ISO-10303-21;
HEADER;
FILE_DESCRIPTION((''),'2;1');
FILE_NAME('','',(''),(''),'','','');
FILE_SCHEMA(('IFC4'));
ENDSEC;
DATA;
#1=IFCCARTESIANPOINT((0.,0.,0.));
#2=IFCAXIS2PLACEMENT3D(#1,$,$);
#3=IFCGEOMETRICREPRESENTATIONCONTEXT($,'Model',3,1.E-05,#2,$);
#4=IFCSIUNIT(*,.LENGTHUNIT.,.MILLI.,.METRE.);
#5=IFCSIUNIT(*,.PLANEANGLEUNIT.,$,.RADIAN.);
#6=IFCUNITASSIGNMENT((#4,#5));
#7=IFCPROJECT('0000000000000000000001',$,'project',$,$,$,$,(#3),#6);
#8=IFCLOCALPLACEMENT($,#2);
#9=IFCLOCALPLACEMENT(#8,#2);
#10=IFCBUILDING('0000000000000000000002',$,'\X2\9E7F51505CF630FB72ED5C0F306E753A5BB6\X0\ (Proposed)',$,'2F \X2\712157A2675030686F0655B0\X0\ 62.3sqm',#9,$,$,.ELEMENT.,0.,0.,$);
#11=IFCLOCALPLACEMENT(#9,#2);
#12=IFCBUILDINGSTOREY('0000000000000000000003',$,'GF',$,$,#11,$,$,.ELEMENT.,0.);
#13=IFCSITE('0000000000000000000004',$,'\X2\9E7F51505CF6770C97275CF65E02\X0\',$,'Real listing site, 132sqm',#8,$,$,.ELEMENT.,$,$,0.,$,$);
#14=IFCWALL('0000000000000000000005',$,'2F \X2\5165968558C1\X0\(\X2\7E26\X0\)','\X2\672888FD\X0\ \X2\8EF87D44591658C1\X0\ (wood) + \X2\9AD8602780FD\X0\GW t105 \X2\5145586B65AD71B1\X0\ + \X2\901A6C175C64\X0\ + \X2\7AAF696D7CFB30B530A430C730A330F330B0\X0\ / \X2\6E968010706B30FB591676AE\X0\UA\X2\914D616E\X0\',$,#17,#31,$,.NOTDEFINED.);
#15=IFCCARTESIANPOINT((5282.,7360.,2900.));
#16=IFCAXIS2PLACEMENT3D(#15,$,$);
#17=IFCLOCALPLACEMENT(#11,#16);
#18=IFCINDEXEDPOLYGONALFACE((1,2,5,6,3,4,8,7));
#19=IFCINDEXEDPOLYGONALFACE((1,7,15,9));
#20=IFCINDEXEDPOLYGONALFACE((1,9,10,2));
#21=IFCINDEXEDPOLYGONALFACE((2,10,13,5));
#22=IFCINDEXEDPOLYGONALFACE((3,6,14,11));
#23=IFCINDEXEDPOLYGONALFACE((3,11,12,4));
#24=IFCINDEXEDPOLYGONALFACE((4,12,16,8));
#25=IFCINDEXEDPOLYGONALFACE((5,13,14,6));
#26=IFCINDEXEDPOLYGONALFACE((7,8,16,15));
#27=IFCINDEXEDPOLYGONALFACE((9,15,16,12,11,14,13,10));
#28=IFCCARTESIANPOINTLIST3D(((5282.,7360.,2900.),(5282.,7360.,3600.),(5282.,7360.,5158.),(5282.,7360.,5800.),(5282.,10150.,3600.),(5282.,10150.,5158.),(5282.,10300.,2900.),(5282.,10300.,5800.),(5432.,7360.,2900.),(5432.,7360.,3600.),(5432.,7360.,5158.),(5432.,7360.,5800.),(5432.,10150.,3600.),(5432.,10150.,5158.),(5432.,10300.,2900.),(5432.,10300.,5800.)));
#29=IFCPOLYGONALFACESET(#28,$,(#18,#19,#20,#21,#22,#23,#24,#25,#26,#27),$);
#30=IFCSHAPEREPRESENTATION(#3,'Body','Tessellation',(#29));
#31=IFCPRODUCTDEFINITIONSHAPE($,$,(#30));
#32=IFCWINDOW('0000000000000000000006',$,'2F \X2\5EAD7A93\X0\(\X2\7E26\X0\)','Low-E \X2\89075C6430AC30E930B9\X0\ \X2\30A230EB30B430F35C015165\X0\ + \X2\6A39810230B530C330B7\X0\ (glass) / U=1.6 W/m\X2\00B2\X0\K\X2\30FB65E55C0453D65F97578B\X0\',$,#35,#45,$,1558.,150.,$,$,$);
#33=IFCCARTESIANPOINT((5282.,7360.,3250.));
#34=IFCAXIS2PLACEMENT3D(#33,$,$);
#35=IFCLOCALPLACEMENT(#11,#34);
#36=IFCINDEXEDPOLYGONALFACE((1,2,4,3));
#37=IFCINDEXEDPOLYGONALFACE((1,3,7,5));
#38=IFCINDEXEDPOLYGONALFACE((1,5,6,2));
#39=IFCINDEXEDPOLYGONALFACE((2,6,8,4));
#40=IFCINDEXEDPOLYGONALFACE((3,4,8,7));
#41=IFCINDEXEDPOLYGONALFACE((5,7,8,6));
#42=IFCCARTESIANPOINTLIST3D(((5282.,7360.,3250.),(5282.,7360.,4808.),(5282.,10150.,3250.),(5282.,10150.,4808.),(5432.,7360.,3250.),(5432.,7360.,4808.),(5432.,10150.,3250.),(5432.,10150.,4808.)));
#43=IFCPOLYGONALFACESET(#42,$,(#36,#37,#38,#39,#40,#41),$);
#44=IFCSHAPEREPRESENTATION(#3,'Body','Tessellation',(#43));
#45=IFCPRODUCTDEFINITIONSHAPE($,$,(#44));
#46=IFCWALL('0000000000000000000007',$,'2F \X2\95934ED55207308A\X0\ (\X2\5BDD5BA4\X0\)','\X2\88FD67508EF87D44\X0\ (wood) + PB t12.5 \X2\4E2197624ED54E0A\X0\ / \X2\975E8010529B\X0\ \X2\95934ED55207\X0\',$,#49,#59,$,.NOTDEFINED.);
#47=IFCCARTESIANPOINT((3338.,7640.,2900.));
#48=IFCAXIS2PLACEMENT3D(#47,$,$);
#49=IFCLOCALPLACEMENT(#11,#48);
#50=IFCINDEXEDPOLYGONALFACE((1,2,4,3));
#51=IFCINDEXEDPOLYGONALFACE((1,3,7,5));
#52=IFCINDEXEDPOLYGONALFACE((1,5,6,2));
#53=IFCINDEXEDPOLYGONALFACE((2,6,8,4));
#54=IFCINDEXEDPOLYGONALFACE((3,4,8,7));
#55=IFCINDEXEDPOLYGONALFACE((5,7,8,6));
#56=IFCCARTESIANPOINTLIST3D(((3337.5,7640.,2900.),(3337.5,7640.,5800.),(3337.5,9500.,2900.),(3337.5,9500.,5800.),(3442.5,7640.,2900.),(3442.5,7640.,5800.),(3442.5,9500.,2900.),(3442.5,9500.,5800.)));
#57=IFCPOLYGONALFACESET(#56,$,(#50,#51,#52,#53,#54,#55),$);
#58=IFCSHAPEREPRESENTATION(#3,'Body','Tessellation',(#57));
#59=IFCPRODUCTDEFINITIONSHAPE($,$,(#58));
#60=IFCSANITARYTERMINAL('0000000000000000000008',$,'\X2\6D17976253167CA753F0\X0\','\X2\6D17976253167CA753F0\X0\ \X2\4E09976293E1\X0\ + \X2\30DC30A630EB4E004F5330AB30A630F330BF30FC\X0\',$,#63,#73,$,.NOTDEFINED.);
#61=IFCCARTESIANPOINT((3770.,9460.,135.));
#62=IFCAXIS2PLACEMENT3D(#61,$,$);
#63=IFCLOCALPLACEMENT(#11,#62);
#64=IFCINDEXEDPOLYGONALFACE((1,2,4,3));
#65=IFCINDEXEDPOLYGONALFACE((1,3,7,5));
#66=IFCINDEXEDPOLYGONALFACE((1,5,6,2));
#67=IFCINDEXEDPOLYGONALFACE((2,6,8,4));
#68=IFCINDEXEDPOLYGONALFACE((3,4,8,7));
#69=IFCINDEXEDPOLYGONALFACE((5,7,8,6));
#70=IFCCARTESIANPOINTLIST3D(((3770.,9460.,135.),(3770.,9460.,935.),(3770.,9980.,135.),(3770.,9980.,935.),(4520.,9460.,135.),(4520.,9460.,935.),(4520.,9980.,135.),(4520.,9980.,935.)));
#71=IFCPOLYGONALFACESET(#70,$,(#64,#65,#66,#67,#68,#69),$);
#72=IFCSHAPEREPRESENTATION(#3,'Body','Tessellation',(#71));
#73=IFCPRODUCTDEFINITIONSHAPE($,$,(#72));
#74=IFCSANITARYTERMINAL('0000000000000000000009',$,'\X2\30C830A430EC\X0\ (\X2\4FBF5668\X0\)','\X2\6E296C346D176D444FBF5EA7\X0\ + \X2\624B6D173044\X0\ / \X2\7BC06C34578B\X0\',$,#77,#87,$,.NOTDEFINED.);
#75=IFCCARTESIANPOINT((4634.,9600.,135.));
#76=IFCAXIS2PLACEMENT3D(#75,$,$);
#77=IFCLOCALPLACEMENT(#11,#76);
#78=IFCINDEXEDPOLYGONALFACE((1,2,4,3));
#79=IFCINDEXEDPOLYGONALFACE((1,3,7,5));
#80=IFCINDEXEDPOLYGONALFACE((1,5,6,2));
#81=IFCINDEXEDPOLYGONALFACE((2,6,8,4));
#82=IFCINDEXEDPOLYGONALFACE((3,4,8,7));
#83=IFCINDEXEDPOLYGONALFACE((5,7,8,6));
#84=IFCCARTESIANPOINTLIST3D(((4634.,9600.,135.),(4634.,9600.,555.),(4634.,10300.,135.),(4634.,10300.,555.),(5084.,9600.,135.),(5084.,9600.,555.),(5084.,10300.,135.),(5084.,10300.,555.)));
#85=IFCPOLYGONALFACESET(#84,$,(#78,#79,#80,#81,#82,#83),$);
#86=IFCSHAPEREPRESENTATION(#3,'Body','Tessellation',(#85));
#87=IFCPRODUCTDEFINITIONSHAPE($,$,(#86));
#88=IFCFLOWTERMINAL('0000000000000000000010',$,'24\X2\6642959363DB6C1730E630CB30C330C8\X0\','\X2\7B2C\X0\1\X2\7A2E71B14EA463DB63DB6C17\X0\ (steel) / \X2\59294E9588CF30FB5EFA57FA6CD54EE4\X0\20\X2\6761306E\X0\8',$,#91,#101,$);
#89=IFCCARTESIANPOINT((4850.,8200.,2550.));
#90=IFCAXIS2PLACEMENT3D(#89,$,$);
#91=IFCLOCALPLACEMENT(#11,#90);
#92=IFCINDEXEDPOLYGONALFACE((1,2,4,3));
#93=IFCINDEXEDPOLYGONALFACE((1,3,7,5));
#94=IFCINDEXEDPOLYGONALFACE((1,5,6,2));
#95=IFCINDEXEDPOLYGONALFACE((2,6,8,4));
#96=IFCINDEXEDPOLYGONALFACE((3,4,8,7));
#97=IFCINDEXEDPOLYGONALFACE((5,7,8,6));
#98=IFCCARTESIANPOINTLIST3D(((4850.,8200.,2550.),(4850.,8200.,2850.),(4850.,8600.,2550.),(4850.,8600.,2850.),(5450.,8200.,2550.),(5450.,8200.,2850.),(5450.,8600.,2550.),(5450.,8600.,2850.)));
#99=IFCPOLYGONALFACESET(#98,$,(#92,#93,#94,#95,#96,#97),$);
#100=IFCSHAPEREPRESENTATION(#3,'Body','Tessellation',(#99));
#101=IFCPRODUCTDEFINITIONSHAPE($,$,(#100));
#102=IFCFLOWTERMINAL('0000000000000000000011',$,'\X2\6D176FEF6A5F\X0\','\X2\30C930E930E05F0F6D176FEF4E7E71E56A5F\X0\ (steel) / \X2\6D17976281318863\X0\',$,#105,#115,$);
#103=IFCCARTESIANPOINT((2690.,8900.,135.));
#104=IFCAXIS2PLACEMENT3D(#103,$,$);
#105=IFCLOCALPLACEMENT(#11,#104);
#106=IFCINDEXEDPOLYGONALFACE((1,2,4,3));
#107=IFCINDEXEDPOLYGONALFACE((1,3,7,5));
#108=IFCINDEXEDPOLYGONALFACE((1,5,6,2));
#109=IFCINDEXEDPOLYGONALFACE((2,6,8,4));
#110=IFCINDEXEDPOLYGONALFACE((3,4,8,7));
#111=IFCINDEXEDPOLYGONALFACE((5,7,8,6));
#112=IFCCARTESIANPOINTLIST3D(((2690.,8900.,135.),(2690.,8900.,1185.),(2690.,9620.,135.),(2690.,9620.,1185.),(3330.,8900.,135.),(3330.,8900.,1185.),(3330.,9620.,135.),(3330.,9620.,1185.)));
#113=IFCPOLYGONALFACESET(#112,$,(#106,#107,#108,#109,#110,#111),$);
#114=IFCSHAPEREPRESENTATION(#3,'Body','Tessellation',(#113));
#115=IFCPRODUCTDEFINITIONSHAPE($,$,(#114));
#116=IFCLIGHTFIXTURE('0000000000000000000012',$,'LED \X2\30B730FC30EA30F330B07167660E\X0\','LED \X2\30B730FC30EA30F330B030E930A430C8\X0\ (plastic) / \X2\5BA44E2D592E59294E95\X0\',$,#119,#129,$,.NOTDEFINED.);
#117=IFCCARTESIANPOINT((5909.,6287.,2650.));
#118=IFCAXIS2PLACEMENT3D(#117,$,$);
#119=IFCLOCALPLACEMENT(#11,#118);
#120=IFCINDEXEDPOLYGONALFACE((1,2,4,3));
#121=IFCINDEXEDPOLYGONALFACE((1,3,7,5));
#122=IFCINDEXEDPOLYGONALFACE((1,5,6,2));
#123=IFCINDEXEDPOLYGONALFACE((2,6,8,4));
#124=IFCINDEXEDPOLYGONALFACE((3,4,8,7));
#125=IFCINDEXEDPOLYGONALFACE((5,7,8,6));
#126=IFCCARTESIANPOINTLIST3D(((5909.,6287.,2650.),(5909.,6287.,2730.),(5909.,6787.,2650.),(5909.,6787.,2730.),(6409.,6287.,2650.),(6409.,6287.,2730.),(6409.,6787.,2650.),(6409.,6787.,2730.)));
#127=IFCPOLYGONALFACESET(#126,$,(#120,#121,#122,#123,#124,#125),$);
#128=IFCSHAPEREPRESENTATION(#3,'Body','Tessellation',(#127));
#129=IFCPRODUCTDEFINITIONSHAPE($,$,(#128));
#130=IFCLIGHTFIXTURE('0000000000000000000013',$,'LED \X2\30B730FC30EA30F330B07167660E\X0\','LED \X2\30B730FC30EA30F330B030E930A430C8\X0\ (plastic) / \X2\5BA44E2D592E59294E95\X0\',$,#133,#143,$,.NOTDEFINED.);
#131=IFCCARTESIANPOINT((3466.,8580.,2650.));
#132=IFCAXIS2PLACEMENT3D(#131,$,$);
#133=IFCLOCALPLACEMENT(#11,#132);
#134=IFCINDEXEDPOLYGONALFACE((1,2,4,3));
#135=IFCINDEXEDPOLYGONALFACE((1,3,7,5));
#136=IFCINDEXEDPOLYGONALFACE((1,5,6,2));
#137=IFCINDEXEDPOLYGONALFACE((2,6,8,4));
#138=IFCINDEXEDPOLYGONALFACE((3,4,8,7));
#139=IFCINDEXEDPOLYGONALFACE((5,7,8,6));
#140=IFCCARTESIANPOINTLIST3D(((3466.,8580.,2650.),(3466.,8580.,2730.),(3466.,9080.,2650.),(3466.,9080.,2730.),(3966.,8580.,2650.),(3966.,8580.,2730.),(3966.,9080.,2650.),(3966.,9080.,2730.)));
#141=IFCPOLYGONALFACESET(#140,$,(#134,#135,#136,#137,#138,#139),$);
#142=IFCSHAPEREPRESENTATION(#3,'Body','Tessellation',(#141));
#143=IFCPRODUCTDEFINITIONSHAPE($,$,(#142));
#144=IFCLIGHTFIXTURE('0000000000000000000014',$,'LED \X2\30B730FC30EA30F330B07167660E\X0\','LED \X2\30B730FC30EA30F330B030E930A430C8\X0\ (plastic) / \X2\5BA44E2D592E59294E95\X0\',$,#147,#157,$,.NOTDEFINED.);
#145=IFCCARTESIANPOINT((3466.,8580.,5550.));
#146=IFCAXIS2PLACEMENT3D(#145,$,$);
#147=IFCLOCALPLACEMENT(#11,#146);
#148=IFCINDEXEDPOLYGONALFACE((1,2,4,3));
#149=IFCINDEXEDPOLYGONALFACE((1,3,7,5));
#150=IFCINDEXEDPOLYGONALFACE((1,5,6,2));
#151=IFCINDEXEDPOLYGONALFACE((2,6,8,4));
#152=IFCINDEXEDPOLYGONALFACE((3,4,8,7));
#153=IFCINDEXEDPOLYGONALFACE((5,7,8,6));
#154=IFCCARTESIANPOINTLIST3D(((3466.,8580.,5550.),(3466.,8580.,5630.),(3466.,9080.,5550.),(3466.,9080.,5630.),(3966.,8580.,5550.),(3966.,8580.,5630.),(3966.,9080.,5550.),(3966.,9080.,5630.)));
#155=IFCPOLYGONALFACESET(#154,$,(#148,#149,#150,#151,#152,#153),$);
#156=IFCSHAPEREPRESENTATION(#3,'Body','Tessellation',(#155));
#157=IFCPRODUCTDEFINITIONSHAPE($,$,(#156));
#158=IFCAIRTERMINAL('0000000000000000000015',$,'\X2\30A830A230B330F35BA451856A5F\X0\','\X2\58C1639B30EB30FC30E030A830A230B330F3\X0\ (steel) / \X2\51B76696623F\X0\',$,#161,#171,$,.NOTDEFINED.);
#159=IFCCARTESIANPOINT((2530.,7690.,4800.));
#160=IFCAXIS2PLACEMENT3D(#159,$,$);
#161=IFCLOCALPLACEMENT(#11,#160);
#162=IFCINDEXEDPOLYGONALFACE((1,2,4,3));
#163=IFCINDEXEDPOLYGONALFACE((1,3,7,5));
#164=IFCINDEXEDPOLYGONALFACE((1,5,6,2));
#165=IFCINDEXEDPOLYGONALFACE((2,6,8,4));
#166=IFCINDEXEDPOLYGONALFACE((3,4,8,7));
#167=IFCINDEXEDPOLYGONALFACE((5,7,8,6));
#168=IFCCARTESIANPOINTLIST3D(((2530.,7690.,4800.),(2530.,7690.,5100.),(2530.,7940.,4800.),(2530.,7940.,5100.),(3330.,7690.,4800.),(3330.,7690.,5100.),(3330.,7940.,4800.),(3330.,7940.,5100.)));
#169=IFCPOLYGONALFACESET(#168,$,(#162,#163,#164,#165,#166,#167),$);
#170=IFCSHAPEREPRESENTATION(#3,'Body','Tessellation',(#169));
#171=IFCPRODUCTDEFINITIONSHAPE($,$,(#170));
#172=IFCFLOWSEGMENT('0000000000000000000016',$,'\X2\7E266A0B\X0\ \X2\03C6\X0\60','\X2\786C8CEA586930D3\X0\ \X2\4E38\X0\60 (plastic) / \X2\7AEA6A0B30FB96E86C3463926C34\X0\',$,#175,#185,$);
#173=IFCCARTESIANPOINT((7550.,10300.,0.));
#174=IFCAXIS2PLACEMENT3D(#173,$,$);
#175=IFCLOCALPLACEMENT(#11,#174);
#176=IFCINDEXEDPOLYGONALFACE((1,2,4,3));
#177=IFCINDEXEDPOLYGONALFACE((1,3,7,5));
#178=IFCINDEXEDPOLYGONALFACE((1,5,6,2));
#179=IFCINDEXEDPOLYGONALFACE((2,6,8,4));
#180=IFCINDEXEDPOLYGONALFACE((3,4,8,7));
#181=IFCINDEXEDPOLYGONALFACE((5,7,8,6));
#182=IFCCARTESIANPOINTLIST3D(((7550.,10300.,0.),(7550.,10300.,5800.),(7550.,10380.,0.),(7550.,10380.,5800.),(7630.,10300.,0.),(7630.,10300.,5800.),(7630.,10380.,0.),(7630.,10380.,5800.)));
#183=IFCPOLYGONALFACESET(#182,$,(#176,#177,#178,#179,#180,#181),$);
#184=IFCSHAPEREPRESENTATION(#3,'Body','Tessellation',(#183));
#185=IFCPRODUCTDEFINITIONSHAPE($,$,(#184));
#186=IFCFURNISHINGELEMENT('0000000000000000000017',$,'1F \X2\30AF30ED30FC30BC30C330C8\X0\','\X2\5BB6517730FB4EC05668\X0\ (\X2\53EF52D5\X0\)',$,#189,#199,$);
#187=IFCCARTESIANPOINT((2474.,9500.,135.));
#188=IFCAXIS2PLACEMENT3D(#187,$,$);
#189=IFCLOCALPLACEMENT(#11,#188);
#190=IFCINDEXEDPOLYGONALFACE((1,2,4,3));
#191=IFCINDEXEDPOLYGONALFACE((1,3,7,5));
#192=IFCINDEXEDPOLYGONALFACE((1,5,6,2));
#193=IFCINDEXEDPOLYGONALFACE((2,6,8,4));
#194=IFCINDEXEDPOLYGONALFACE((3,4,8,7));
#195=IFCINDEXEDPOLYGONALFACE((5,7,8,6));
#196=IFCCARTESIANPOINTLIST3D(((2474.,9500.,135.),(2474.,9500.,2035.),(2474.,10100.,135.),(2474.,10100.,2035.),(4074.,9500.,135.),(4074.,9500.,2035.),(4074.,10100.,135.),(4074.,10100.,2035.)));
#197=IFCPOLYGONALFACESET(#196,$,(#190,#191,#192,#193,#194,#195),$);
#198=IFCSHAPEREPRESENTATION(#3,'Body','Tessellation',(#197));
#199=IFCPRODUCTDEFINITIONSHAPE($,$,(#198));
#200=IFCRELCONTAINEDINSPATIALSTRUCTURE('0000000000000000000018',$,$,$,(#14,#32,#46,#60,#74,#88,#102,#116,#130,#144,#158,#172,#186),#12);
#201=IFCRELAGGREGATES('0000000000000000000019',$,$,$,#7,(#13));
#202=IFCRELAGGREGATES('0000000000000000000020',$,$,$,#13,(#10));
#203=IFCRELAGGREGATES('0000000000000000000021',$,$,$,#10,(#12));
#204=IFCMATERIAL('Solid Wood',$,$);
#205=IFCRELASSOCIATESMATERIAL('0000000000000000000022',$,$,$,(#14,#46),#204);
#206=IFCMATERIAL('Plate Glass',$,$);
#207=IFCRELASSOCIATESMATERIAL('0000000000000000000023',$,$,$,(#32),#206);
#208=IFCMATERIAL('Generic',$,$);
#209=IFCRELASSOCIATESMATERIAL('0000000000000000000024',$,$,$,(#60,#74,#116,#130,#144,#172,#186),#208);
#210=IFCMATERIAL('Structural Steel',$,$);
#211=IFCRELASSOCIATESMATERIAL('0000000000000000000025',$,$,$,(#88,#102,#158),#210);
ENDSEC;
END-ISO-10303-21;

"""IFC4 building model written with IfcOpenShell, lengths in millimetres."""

from ifc_helpers import new_model, si_unit, frame, frame_2d, origin, place, context, project, spatial, rectangle, extrude, material, element, fill, save


model = new_model("IFC4")

# Units and contexts
model_context = context("Model", 3, precision=1e-05, world=origin())
ifc_project = project(units=[si_unit("LENGTHUNIT", "METRE", prefix="MILLI"), si_unit("PLANEANGLEUNIT", "RADIAN")], contexts=[model_context])

# Site, building, storey
site_placement = place(None, origin())
site = spatial("IfcSite", under=ifc_project, at=site_placement, Name="鹿児島県霧島市", ObjectType="Real listing site, 132sqm", CompositionType="ELEMENT", RefElevation=0.0)
building_placement = place(site_placement, origin())
building = spatial("IfcBuilding", under=site, at=building_placement, Name="鹿児島・狭小の町家 (Proposed)", ObjectType="2F 無垢材と漆喰 62.3sqm", CompositionType="ELEMENT", ElevationOfRefHeight=0.0, ElevationOfTerrain=0.0)
storey_placement = place(building_placement, origin())
storey = spatial("IfcBuildingStorey", under=building, at=storey_placement, Name="GF", CompositionType="ELEMENT", Elevation=0.0)

# Shared definitions
ifc_material_1 = material(Name="Solid Wood")

# Shared definitions
ifc_material_2 = material(Name="Plate Glass")

# Wall, opening, window
wall_1_placement = place(storey_placement, frame((5282.0, 7360.0, 2900.0)))
wall_1 = element("IfcWall", 1, at=wall_1_placement, inside=storey, material=ifc_material_1, Name="2F 入隅壁(縦)", Description="木製 軸組外壁 (wood) + 高性能GW t105 充填断熱 + 通気層 + 窯業系サイディング / 準耐火・外皮UA配慮", PredefinedType="NOTDEFINED", context=model_context, shape_type="SweptSolid", body=[
    extrude(rectangle(XDim=150.0, YDim=2940.0, at=frame_2d((75.0, 1470.0))), frame((5282.0, 7360.0, 2900.0)), (0.0, 0.0, 1.0), 2900.0),
])
opening_1_placement = place(storey_placement, frame((5282.0, 7360.0, 3250.0)))
opening_1 = element("IfcOpeningElement", 2, at=opening_1_placement, cuts=wall_1, PredefinedType="NOTDEFINED", context=model_context, shape_type="SweptSolid", body=[
    extrude(rectangle(XDim=150.0, YDim=2790.0, at=frame_2d((75.0, 1395.0))), frame((5282.0, 7360.0, 3250.0)), (0.0, 0.0, 1.0), 1558.0),
])
window_1_placement = place(storey_placement, frame((5282.0, 7360.0, 3250.0)))
window_1 = element("IfcWindow", 3, at=window_1_placement, inside=storey, material=ifc_material_2, Name="2F 庭窓(縦)", Description="Low-E 複層ガラス アルゴン封入 + 樹脂サッシ (glass) / U=1.6 W/m²K・日射取得型", OverallHeight=1558.0, OverallWidth=150.0, context=model_context, shape_type="SweptSolid", body=[
    extrude(rectangle(XDim=150.0, YDim=2790.0, at=frame_2d((75.0, 1395.0))), frame((5282.0, 7360.0, 3250.0)), (0.0, 0.0, 1.0), 1558.0),
])
fill(opening_1, window_1)

# Wall
wall_2_placement = place(storey_placement, frame((3338.0, 7640.0, 2900.0)))
element("IfcWall", 4, at=wall_2_placement, inside=storey, material=ifc_material_1, Name="2F 間仕切り (寝室)", Description="製材軸組 (wood) + PB t12.5 両面仕上 / 非耐力 間仕切", PredefinedType="NOTDEFINED", context=model_context, shape_type="SweptSolid", body=[
    extrude(rectangle(XDim=105.0, YDim=1860.0, at=frame_2d((52.0, 930.0))), frame((3338.0, 7640.0, 2900.0)), (0.0, 0.0, 1.0), 2900.0),
])

# Sanitary terminals
ifc_material_3 = material(Name="Generic")
sanitary_terminal_1_placement = place(storey_placement, frame((3770.0, 9460.0, 135.0)))
element("IfcSanitaryTerminal", 5, at=sanitary_terminal_1_placement, inside=storey, material=ifc_material_3, Name="洗面化粧台", Description="洗面化粧台 三面鏡 + ボウル一体カウンター", PredefinedType="NOTDEFINED", context=model_context, shape_type="SweptSolid", body=[
    extrude(rectangle(XDim=750.0, YDim=520.0, at=frame_2d((375.0, 260.0))), frame((3770.0, 9460.0, 135.0)), (0.0, 0.0, 1.0), 800.0),
])
sanitary_terminal_2_placement = place(storey_placement, frame((4634.0, 9600.0, 135.0)))
element("IfcSanitaryTerminal", 6, at=sanitary_terminal_2_placement, inside=storey, material=ifc_material_3, Name="トイレ (便器)", Description="温水洗浄便座 + 手洗い / 節水型", PredefinedType="NOTDEFINED", context=model_context, shape_type="SweptSolid", body=[
    extrude(rectangle(XDim=450.0, YDim=700.0, at=frame_2d((225.0, 350.0))), frame((4634.0, 9600.0, 135.0)), (0.0, 0.0, 1.0), 420.0),
])

# Flow terminals
ifc_material_4 = material(Name="Structural Steel")
flow_terminal_1_placement = place(storey_placement, frame((4850.0, 8200.0, 2550.0)))
element("IfcFlowTerminal", 7, at=flow_terminal_1_placement, inside=storey, material=ifc_material_4, Name="24時間換気ユニット", Description="第1種熱交換換気 (steel) / 天井裏・建基法令20条の8", context=model_context, shape_type="SweptSolid", body=[
    extrude(rectangle(XDim=600.0, YDim=400.0, at=frame_2d((300.0, 200.0))), frame((4850.0, 8200.0, 2550.0)), (0.0, 0.0, 1.0), 300.0),
])
flow_terminal_2_placement = place(storey_placement, frame((2690.0, 8900.0, 135.0)))
element("IfcFlowTerminal", 8, at=flow_terminal_2_placement, inside=storey, material=ifc_material_4, Name="洗濯機", Description="ドラム式洗濯乾燥機 (steel) / 洗面脱衣", context=model_context, shape_type="SweptSolid", body=[
    extrude(rectangle(XDim=640.0, YDim=720.0, at=frame_2d((320.0, 360.0))), frame((2690.0, 8900.0, 135.0)), (0.0, 0.0, 1.0), 1050.0),
])

# Light fixtures
light_fixture_1_placement = place(storey_placement, frame((5909.0, 6287.0, 2650.0)))
element("IfcLightFixture", 9, at=light_fixture_1_placement, inside=storey, material=ifc_material_3, Name="LED シーリング照明", Description="LED シーリングライト (plastic) / 室中央天井", PredefinedType="NOTDEFINED", context=model_context, shape_type="SweptSolid", body=[
    extrude(rectangle(XDim=500.0, YDim=500.0, at=frame_2d((250.0, 250.0))), frame((5909.0, 6287.0, 2650.0)), (0.0, 0.0, 1.0), 80.0),
])
light_fixture_2_placement = place(storey_placement, frame((3466.0, 8580.0, 2650.0)))
element("IfcLightFixture", 10, at=light_fixture_2_placement, inside=storey, material=ifc_material_3, Name="LED シーリング照明", Description="LED シーリングライト (plastic) / 室中央天井", PredefinedType="NOTDEFINED", context=model_context, shape_type="SweptSolid", body=[
    extrude(rectangle(XDim=500.0, YDim=500.0, at=frame_2d((250.0, 250.0))), frame((3466.0, 8580.0, 2650.0)), (0.0, 0.0, 1.0), 80.0),
])
light_fixture_3_placement = place(storey_placement, frame((3466.0, 8580.0, 5550.0)))
element("IfcLightFixture", 11, at=light_fixture_3_placement, inside=storey, material=ifc_material_3, Name="LED シーリング照明", Description="LED シーリングライト (plastic) / 室中央天井", PredefinedType="NOTDEFINED", context=model_context, shape_type="SweptSolid", body=[
    extrude(rectangle(XDim=500.0, YDim=500.0, at=frame_2d((250.0, 250.0))), frame((3466.0, 8580.0, 5550.0)), (0.0, 0.0, 1.0), 80.0),
])

# Air terminal
air_terminal_placement = place(storey_placement, frame((2530.0, 7690.0, 4800.0)))
element("IfcAirTerminal", 12, at=air_terminal_placement, inside=storey, material=ifc_material_4, Name="エアコン室内機", Description="壁掛ルームエアコン (steel) / 冷暖房", PredefinedType="NOTDEFINED", context=model_context, shape_type="SweptSolid", body=[
    extrude(rectangle(XDim=800.0, YDim=250.0, at=frame_2d((400.0, 125.0))), frame((2530.0, 7690.0, 4800.0)), (0.0, 0.0, 1.0), 300.0),
])

# Flow segment
flow_segment_placement = place(storey_placement, frame((7550.0, 10300.0, 0.0)))
element("IfcFlowSegment", 13, at=flow_segment_placement, inside=storey, material=ifc_material_3, Name="縦樋 φ60", Description="硬質塩ビ 丸60 (plastic) / 竪樋・雨水排水", context=model_context, shape_type="SweptSolid", body=[
    extrude(rectangle(XDim=80.0, YDim=80.0, at=frame_2d((40.0, 40.0))), frame((7550.0, 10300.0, 0.0)), (0.0, 0.0, 1.0), 5800.0),
])

# Furnishing element
furnishing_1_placement = place(storey_placement, frame((2474.0, 9500.0, 135.0)))
element("IfcFurnishingElement", 14, at=furnishing_1_placement, inside=storey, material=ifc_material_3, Name="1F クローゼット", Description="家具・什器 (可動)", context=model_context, shape_type="SweptSolid", body=[
    extrude(rectangle(XDim=1600.0, YDim=600.0, at=frame_2d((800.0, 300.0))), frame((2474.0, 9500.0, 135.0)), (0.0, 0.0, 1.0), 1900.0),
])

save(model, "model.ifc")
